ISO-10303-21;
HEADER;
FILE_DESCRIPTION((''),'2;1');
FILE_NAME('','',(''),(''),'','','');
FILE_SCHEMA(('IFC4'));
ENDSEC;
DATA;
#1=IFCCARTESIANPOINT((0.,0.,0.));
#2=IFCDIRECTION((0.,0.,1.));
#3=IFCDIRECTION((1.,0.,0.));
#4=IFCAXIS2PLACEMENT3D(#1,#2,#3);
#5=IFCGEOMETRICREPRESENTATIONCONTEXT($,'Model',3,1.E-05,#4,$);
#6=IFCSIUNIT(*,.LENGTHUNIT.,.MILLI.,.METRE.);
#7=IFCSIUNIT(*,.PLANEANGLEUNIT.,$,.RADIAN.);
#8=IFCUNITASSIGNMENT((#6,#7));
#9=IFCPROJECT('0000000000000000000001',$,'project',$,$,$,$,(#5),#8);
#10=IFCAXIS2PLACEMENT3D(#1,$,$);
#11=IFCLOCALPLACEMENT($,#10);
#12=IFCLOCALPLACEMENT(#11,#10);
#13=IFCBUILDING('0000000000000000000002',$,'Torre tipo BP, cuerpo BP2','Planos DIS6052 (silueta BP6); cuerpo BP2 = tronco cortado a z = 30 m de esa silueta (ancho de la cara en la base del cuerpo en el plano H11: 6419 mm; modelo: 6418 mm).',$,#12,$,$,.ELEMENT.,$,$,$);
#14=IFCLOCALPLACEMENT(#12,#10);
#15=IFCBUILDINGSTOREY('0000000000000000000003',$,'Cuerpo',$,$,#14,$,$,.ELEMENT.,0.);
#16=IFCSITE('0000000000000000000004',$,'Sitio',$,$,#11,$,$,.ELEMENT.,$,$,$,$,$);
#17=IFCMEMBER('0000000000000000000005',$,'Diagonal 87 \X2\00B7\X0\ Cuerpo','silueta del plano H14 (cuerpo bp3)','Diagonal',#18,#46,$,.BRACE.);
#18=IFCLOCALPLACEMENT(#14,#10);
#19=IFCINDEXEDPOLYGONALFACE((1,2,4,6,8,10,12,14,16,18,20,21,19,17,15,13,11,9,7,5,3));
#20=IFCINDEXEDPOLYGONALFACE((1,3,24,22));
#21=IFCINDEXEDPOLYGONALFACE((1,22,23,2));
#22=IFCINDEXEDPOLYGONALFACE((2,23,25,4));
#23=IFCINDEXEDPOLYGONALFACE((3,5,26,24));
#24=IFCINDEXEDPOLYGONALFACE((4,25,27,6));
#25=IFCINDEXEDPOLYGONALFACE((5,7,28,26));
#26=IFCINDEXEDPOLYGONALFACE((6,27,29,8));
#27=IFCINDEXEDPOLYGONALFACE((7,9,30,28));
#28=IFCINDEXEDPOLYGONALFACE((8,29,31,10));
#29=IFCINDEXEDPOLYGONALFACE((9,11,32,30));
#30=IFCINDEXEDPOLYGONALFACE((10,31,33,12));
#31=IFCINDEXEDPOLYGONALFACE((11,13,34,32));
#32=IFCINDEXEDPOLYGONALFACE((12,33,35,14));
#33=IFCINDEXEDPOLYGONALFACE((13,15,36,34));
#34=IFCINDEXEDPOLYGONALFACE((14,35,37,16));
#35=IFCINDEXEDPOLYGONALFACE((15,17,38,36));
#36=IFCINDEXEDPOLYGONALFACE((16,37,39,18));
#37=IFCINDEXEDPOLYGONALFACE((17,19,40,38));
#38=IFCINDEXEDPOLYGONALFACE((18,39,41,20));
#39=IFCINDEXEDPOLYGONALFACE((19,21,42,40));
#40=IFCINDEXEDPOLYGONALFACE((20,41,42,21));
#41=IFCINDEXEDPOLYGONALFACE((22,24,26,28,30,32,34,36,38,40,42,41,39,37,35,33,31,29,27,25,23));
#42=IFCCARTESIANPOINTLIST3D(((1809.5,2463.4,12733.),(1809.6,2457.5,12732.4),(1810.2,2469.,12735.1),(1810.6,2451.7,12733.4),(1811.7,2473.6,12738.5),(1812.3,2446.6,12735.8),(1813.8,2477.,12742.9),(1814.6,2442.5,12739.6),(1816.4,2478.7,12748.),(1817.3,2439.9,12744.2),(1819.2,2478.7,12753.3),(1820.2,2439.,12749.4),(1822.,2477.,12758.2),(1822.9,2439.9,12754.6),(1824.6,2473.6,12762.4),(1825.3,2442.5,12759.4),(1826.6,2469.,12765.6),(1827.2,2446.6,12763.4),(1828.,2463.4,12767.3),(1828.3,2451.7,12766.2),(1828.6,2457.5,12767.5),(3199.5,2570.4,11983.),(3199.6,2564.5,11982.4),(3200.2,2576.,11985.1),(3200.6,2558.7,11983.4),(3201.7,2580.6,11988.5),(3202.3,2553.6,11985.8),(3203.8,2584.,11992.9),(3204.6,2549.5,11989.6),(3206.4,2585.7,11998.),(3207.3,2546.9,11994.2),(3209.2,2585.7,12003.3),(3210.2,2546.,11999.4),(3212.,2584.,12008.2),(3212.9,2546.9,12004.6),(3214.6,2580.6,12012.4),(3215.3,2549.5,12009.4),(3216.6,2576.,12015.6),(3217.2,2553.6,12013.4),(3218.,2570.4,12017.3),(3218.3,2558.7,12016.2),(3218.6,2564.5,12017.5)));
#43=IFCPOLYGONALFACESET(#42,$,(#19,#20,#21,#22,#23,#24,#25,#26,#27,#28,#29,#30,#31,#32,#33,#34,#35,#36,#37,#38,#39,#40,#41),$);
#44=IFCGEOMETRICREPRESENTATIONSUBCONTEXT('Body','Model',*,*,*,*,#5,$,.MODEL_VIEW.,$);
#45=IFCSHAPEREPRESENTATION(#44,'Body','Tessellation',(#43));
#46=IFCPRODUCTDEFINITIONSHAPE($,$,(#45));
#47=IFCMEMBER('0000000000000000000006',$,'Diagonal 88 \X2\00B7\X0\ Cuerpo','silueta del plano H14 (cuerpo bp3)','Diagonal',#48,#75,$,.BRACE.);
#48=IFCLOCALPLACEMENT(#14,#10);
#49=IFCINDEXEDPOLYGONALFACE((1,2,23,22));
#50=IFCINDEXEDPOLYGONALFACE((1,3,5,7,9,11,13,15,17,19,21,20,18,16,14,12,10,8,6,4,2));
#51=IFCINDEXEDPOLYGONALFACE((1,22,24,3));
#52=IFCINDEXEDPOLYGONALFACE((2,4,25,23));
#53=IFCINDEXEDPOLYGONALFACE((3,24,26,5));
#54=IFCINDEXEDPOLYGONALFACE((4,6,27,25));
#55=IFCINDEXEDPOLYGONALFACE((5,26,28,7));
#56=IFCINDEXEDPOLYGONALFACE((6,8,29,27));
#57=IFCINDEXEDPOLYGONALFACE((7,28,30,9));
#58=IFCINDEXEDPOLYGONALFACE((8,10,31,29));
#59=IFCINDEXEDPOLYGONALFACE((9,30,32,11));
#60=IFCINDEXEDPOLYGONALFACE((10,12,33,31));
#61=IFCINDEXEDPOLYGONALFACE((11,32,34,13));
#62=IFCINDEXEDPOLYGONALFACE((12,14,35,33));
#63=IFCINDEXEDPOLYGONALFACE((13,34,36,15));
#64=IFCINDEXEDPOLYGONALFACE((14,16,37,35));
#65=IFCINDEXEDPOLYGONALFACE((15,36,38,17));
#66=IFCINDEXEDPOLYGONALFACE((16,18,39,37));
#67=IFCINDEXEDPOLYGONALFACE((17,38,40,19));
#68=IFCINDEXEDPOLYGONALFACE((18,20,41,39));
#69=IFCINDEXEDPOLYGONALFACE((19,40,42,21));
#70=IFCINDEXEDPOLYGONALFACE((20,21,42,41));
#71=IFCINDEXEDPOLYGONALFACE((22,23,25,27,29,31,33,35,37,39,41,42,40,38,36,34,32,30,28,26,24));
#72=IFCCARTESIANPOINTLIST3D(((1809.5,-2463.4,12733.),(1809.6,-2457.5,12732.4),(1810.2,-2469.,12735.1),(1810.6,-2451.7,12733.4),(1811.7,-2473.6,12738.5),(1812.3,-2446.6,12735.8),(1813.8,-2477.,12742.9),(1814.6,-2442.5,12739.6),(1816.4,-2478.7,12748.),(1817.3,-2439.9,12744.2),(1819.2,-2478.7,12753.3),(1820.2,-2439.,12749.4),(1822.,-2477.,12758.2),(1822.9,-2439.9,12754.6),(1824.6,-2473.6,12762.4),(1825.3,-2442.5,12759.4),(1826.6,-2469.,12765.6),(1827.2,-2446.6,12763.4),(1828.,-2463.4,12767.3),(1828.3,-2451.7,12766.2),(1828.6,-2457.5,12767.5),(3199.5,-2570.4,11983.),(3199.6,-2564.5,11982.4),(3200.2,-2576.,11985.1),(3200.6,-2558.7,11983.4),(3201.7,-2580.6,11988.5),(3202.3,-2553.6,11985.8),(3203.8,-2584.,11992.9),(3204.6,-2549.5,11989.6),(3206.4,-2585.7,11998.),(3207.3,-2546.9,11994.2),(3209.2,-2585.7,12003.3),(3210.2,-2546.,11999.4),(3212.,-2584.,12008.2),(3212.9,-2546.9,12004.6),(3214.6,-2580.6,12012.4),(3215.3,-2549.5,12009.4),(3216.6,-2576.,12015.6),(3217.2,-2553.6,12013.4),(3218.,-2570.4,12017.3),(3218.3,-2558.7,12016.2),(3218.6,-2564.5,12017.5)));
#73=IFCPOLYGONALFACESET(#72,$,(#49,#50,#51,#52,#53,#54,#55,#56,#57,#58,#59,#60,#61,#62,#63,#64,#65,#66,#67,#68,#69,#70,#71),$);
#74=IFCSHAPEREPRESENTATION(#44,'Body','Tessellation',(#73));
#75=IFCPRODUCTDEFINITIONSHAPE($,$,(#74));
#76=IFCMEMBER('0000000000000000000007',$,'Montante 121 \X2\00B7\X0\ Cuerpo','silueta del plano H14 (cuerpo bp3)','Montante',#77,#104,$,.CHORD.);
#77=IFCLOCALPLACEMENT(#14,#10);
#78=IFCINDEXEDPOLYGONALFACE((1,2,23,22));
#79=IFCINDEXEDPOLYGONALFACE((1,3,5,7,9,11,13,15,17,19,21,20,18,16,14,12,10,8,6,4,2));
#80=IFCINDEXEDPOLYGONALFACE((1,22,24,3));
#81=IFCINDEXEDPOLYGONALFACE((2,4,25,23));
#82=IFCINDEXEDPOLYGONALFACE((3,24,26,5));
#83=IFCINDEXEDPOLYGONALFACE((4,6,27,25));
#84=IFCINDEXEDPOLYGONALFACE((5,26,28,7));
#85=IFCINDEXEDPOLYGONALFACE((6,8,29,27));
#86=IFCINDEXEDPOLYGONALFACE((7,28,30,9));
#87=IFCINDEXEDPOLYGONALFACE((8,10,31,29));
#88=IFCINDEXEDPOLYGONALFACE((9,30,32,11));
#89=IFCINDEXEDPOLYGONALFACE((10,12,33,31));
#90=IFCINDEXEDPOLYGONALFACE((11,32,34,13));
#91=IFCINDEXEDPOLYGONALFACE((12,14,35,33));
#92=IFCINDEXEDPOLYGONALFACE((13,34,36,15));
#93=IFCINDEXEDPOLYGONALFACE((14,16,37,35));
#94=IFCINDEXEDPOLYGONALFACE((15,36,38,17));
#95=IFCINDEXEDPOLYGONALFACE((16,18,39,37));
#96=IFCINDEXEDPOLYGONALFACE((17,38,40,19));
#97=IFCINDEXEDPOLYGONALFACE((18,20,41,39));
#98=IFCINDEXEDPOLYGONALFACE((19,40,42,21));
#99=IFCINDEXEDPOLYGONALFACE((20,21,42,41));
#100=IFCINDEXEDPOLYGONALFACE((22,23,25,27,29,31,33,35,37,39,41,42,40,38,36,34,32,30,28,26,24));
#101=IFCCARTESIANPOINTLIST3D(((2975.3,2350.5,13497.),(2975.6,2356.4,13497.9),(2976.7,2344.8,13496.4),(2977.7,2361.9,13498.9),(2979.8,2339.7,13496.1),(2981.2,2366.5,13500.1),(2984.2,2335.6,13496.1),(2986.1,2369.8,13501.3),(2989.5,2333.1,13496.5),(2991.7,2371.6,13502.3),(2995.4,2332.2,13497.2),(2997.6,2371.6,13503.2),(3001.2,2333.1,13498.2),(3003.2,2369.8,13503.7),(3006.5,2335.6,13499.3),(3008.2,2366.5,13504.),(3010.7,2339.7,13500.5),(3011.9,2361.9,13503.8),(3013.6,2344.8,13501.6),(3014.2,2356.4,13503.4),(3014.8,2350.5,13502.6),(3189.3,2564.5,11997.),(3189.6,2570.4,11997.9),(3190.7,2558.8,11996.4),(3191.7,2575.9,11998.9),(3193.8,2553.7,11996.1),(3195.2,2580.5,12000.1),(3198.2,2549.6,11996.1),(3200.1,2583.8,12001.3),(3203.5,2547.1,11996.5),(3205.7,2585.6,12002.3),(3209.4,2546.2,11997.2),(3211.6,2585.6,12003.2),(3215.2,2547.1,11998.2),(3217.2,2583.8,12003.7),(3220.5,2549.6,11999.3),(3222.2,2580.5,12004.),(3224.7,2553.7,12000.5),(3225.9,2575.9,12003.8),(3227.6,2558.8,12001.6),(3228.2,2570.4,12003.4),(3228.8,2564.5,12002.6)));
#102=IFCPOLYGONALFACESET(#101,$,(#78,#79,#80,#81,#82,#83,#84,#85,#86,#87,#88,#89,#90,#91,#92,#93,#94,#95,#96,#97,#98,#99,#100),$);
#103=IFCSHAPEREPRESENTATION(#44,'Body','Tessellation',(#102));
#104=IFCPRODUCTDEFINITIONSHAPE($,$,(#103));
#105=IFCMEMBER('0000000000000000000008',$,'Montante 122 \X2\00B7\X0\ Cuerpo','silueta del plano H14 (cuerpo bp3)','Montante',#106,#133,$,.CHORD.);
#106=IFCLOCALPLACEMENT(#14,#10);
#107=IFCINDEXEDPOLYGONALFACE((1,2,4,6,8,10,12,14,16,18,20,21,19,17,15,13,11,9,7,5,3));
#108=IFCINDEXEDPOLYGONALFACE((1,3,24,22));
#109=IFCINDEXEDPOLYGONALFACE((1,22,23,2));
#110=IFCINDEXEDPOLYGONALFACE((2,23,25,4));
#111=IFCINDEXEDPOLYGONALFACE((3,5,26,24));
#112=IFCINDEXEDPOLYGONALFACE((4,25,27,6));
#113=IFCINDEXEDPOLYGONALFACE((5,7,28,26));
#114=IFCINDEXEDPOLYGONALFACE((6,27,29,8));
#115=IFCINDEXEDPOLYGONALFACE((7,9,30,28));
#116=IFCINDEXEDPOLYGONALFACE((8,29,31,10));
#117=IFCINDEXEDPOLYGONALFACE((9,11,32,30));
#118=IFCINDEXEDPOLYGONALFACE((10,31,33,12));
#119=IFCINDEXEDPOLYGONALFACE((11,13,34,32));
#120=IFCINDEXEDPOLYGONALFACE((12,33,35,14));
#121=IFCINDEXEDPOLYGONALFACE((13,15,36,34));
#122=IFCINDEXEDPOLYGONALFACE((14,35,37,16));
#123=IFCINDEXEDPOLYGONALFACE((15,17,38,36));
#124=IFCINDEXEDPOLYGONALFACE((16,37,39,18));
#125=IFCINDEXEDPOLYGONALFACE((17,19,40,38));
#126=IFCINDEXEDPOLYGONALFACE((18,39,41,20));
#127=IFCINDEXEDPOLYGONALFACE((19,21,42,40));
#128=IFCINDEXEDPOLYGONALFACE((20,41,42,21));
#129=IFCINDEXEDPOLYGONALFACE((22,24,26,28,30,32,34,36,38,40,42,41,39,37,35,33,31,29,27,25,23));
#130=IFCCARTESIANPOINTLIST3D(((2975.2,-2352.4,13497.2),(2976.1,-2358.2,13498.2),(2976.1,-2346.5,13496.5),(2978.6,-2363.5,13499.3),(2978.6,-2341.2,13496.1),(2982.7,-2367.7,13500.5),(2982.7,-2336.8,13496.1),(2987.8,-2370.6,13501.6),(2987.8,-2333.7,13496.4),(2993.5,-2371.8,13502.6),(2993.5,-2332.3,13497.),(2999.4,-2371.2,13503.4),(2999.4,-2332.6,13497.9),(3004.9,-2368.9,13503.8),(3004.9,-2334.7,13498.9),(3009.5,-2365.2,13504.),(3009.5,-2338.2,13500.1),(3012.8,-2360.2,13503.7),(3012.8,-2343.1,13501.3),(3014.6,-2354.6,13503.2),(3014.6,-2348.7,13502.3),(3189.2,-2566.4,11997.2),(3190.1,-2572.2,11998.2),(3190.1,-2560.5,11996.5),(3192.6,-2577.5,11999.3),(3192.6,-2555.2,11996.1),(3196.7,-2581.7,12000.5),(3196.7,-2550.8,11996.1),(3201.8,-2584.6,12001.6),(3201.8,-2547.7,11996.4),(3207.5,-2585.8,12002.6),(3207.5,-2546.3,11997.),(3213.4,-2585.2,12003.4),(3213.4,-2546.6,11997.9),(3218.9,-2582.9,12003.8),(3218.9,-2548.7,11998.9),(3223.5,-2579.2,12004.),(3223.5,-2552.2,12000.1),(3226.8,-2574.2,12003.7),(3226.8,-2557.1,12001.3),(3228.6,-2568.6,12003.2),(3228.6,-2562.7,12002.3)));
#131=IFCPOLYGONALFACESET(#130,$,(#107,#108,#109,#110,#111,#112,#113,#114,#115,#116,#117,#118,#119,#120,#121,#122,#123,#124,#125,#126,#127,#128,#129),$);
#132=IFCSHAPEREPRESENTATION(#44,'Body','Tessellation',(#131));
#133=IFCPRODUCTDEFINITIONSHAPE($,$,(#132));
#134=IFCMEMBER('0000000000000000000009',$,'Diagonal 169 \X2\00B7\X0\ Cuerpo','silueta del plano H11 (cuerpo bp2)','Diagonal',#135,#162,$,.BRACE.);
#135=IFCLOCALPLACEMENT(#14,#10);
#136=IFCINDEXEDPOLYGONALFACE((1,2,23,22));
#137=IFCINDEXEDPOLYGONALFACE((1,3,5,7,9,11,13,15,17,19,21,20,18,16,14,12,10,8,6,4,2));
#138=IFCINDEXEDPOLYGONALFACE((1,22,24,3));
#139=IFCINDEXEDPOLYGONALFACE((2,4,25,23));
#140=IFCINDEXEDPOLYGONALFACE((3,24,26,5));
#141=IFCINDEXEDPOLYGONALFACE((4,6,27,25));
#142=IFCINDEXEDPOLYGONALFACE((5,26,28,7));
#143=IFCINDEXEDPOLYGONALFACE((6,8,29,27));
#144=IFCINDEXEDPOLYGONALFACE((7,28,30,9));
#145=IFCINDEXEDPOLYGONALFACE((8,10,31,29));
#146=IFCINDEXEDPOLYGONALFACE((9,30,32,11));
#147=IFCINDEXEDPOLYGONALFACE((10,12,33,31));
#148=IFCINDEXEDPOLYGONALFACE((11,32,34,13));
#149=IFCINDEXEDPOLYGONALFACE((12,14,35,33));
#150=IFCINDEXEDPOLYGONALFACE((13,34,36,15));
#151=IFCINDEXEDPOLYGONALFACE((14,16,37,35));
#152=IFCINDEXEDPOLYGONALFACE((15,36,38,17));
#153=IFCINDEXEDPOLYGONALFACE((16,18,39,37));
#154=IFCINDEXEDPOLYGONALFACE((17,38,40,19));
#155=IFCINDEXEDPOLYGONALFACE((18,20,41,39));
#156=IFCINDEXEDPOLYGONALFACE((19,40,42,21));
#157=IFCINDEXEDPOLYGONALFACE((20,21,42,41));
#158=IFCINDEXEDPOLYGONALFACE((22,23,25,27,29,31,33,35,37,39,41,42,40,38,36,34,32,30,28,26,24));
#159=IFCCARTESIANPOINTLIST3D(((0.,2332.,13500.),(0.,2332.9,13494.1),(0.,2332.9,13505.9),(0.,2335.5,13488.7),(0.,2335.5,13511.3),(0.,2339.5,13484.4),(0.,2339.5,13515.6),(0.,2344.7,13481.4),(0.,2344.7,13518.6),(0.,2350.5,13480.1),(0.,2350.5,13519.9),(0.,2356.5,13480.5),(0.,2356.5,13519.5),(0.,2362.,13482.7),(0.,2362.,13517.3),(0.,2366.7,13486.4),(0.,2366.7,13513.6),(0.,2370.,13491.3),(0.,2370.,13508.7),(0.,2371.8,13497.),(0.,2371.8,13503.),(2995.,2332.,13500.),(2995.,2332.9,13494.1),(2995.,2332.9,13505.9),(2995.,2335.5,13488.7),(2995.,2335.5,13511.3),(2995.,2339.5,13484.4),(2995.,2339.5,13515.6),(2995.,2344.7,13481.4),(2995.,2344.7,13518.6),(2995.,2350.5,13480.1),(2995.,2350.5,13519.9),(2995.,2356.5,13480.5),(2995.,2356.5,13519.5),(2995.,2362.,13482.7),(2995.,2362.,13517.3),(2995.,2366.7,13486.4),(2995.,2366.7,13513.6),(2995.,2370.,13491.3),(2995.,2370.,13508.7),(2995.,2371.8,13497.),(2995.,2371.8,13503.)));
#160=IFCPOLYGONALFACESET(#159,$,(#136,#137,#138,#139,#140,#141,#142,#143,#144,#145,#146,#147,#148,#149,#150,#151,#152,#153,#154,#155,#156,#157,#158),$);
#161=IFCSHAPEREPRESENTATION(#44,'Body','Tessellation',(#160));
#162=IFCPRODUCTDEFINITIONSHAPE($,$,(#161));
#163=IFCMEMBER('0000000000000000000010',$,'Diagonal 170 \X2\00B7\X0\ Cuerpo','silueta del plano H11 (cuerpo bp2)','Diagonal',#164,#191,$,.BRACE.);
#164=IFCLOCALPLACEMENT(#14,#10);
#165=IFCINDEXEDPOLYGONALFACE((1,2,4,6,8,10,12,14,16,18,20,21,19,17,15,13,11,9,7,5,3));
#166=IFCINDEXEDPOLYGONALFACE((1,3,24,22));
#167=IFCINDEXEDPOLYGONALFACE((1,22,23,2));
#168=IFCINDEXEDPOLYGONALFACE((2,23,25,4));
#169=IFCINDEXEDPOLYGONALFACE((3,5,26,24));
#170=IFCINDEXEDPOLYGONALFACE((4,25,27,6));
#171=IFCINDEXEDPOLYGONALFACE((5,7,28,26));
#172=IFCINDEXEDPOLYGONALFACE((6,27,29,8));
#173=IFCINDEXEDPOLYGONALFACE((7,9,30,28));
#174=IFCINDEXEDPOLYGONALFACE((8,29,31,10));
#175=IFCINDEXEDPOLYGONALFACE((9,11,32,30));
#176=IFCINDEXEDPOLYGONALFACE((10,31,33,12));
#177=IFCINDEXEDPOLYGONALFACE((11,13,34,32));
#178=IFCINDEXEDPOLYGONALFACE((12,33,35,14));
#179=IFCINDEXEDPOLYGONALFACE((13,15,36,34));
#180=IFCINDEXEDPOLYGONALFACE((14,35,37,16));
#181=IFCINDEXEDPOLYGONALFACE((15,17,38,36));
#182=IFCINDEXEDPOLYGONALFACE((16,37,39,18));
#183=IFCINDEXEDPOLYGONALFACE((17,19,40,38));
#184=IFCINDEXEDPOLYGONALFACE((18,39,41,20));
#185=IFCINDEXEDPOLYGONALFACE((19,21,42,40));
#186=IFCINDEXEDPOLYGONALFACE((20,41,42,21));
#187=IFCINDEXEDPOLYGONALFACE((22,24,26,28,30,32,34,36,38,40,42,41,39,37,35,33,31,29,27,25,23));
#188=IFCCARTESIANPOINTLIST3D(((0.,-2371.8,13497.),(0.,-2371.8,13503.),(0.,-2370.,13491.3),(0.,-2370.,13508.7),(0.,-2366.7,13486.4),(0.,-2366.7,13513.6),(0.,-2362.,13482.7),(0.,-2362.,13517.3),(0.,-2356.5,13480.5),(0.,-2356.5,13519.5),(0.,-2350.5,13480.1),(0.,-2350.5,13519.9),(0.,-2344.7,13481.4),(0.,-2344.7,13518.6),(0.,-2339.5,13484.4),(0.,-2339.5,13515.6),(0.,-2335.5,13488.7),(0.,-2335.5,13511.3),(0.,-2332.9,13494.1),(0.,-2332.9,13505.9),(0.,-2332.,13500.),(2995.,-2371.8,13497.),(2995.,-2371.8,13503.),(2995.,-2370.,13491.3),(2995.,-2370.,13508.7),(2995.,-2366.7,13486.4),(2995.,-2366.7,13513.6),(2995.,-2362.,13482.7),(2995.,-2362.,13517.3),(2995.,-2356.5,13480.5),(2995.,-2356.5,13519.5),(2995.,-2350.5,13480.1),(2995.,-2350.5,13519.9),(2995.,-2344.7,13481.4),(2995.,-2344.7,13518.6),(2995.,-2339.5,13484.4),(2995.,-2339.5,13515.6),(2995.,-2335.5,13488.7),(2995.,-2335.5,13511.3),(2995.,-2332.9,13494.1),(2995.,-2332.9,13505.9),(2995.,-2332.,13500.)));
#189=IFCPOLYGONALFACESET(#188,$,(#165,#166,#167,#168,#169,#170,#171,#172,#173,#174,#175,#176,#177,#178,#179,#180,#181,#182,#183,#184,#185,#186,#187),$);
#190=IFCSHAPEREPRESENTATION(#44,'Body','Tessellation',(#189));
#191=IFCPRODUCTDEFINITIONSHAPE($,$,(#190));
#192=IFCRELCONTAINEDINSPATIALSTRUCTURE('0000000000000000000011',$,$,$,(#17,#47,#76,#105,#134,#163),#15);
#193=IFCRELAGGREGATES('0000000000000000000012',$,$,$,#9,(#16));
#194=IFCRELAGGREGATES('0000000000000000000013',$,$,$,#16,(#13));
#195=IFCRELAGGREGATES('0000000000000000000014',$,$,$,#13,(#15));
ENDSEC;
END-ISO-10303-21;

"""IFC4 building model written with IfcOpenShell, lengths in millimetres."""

from ifc_helpers import new_model, si_unit, frame, origin, origin_with_axes, place, context, subcontext, project, spatial, circle, extrude, element, save


model = new_model("IFC4")

# Units and contexts
model_context = context("Model", 3, precision=1e-05, world=origin_with_axes())
body_context = subcontext(model_context, "Body", "Model", "MODEL_VIEW")
ifc_project = project(units=[si_unit("LENGTHUNIT", "METRE", prefix="MILLI"), si_unit("PLANEANGLEUNIT", "RADIAN")], contexts=[model_context])

# Site, building, storey
site_placement = place(None, origin())
site = spatial("IfcSite", under=ifc_project, at=site_placement, Name="Sitio", CompositionType="ELEMENT")
building_placement = place(site_placement, origin())
building = spatial("IfcBuilding", under=site, at=building_placement, Name="Torre tipo BP, cuerpo BP2", Description="Planos DIS6052 (silueta BP6); cuerpo BP2 = tronco cortado a z = 30 m de esa silueta (ancho de la cara en la base del cuerpo en el plano H11: 6419 mm; modelo: 6418 mm).", CompositionType="ELEMENT")
storey_placement = place(building_placement, origin())
storey = spatial("IfcBuildingStorey", under=building, at=storey_placement, Name="Cuerpo", CompositionType="ELEMENT", Elevation=0.0)

# Members
for number, where, z_axis, x_axis, name in (
    (1, (3209.0, 2566.0, 12000.0), (-0.878052, -0.067591, 0.473769), (0.059484, -0.997713, -0.032096), "Diagonal 87 · Cuerpo"),
    (2, (3209.0, -2566.0, 12000.0), (-0.878052, 0.067591, 0.473769), (0.059484, 0.997713, -0.032096), "Diagonal 88 · Cuerpo"),
):
    element("IfcMember", number, at=place(storey_placement, frame(where, z_axis=z_axis, x_axis=x_axis)), inside=storey, Name=name, Description="silueta del plano H14 (cuerpo bp3)", ObjectType="Diagonal", PredefinedType="BRACE", context=body_context, shape_type="SweptSolid", body=[
        extrude(circle(Radius=20.0), None, (0.0, 0.0, 1.0), 1583.1),
    ])
for number, where, z_axis, x_axis, name in (
    (3, (2995.0, 2352.0, 13500.0), (0.139849, 0.139849, -0.980247), (0.019752, -0.990173, -0.138447), "Montante 121 · Cuerpo"),
    (4, (2995.0, -2352.0, 13500.0), (0.139849, -0.139849, -0.980247), (-0.990173, -0.019752, -0.138447), "Montante 122 · Cuerpo"),
):
    element("IfcMember", number, at=place(storey_placement, frame(where, z_axis=z_axis, x_axis=x_axis)), inside=storey, Name=name, Description="silueta del plano H14 (cuerpo bp3)", ObjectType="Montante", PredefinedType="CHORD", context=body_context, shape_type="SweptSolid", body=[
        extrude(circle(Radius=20.0), None, (0.0, 0.0, 1.0), 1530.2),
    ])
for number, where, z_axis, x_axis, name in (
    (5, (2995.0, 2352.0, 13500.0), (-1.0, 0.0, 0.0), (0.0, -1.0, 0.0), "Diagonal 169 · Cuerpo"),
    (6, (2995.0, -2352.0, 13500.0), (-1.0, 0.0, 0.0), (0.0, 1.0, 0.0), "Diagonal 170 · Cuerpo"),
):
    element("IfcMember", number, at=place(storey_placement, frame(where, z_axis=z_axis, x_axis=x_axis)), inside=storey, Name=name, Description="silueta del plano H11 (cuerpo bp2)", ObjectType="Diagonal", PredefinedType="BRACE", context=body_context, shape_type="SweptSolid", body=[
        extrude(circle(Radius=20.0), None, (0.0, 0.0, 1.0), 2995.0),
    ])

save(model, "model.ifc")
